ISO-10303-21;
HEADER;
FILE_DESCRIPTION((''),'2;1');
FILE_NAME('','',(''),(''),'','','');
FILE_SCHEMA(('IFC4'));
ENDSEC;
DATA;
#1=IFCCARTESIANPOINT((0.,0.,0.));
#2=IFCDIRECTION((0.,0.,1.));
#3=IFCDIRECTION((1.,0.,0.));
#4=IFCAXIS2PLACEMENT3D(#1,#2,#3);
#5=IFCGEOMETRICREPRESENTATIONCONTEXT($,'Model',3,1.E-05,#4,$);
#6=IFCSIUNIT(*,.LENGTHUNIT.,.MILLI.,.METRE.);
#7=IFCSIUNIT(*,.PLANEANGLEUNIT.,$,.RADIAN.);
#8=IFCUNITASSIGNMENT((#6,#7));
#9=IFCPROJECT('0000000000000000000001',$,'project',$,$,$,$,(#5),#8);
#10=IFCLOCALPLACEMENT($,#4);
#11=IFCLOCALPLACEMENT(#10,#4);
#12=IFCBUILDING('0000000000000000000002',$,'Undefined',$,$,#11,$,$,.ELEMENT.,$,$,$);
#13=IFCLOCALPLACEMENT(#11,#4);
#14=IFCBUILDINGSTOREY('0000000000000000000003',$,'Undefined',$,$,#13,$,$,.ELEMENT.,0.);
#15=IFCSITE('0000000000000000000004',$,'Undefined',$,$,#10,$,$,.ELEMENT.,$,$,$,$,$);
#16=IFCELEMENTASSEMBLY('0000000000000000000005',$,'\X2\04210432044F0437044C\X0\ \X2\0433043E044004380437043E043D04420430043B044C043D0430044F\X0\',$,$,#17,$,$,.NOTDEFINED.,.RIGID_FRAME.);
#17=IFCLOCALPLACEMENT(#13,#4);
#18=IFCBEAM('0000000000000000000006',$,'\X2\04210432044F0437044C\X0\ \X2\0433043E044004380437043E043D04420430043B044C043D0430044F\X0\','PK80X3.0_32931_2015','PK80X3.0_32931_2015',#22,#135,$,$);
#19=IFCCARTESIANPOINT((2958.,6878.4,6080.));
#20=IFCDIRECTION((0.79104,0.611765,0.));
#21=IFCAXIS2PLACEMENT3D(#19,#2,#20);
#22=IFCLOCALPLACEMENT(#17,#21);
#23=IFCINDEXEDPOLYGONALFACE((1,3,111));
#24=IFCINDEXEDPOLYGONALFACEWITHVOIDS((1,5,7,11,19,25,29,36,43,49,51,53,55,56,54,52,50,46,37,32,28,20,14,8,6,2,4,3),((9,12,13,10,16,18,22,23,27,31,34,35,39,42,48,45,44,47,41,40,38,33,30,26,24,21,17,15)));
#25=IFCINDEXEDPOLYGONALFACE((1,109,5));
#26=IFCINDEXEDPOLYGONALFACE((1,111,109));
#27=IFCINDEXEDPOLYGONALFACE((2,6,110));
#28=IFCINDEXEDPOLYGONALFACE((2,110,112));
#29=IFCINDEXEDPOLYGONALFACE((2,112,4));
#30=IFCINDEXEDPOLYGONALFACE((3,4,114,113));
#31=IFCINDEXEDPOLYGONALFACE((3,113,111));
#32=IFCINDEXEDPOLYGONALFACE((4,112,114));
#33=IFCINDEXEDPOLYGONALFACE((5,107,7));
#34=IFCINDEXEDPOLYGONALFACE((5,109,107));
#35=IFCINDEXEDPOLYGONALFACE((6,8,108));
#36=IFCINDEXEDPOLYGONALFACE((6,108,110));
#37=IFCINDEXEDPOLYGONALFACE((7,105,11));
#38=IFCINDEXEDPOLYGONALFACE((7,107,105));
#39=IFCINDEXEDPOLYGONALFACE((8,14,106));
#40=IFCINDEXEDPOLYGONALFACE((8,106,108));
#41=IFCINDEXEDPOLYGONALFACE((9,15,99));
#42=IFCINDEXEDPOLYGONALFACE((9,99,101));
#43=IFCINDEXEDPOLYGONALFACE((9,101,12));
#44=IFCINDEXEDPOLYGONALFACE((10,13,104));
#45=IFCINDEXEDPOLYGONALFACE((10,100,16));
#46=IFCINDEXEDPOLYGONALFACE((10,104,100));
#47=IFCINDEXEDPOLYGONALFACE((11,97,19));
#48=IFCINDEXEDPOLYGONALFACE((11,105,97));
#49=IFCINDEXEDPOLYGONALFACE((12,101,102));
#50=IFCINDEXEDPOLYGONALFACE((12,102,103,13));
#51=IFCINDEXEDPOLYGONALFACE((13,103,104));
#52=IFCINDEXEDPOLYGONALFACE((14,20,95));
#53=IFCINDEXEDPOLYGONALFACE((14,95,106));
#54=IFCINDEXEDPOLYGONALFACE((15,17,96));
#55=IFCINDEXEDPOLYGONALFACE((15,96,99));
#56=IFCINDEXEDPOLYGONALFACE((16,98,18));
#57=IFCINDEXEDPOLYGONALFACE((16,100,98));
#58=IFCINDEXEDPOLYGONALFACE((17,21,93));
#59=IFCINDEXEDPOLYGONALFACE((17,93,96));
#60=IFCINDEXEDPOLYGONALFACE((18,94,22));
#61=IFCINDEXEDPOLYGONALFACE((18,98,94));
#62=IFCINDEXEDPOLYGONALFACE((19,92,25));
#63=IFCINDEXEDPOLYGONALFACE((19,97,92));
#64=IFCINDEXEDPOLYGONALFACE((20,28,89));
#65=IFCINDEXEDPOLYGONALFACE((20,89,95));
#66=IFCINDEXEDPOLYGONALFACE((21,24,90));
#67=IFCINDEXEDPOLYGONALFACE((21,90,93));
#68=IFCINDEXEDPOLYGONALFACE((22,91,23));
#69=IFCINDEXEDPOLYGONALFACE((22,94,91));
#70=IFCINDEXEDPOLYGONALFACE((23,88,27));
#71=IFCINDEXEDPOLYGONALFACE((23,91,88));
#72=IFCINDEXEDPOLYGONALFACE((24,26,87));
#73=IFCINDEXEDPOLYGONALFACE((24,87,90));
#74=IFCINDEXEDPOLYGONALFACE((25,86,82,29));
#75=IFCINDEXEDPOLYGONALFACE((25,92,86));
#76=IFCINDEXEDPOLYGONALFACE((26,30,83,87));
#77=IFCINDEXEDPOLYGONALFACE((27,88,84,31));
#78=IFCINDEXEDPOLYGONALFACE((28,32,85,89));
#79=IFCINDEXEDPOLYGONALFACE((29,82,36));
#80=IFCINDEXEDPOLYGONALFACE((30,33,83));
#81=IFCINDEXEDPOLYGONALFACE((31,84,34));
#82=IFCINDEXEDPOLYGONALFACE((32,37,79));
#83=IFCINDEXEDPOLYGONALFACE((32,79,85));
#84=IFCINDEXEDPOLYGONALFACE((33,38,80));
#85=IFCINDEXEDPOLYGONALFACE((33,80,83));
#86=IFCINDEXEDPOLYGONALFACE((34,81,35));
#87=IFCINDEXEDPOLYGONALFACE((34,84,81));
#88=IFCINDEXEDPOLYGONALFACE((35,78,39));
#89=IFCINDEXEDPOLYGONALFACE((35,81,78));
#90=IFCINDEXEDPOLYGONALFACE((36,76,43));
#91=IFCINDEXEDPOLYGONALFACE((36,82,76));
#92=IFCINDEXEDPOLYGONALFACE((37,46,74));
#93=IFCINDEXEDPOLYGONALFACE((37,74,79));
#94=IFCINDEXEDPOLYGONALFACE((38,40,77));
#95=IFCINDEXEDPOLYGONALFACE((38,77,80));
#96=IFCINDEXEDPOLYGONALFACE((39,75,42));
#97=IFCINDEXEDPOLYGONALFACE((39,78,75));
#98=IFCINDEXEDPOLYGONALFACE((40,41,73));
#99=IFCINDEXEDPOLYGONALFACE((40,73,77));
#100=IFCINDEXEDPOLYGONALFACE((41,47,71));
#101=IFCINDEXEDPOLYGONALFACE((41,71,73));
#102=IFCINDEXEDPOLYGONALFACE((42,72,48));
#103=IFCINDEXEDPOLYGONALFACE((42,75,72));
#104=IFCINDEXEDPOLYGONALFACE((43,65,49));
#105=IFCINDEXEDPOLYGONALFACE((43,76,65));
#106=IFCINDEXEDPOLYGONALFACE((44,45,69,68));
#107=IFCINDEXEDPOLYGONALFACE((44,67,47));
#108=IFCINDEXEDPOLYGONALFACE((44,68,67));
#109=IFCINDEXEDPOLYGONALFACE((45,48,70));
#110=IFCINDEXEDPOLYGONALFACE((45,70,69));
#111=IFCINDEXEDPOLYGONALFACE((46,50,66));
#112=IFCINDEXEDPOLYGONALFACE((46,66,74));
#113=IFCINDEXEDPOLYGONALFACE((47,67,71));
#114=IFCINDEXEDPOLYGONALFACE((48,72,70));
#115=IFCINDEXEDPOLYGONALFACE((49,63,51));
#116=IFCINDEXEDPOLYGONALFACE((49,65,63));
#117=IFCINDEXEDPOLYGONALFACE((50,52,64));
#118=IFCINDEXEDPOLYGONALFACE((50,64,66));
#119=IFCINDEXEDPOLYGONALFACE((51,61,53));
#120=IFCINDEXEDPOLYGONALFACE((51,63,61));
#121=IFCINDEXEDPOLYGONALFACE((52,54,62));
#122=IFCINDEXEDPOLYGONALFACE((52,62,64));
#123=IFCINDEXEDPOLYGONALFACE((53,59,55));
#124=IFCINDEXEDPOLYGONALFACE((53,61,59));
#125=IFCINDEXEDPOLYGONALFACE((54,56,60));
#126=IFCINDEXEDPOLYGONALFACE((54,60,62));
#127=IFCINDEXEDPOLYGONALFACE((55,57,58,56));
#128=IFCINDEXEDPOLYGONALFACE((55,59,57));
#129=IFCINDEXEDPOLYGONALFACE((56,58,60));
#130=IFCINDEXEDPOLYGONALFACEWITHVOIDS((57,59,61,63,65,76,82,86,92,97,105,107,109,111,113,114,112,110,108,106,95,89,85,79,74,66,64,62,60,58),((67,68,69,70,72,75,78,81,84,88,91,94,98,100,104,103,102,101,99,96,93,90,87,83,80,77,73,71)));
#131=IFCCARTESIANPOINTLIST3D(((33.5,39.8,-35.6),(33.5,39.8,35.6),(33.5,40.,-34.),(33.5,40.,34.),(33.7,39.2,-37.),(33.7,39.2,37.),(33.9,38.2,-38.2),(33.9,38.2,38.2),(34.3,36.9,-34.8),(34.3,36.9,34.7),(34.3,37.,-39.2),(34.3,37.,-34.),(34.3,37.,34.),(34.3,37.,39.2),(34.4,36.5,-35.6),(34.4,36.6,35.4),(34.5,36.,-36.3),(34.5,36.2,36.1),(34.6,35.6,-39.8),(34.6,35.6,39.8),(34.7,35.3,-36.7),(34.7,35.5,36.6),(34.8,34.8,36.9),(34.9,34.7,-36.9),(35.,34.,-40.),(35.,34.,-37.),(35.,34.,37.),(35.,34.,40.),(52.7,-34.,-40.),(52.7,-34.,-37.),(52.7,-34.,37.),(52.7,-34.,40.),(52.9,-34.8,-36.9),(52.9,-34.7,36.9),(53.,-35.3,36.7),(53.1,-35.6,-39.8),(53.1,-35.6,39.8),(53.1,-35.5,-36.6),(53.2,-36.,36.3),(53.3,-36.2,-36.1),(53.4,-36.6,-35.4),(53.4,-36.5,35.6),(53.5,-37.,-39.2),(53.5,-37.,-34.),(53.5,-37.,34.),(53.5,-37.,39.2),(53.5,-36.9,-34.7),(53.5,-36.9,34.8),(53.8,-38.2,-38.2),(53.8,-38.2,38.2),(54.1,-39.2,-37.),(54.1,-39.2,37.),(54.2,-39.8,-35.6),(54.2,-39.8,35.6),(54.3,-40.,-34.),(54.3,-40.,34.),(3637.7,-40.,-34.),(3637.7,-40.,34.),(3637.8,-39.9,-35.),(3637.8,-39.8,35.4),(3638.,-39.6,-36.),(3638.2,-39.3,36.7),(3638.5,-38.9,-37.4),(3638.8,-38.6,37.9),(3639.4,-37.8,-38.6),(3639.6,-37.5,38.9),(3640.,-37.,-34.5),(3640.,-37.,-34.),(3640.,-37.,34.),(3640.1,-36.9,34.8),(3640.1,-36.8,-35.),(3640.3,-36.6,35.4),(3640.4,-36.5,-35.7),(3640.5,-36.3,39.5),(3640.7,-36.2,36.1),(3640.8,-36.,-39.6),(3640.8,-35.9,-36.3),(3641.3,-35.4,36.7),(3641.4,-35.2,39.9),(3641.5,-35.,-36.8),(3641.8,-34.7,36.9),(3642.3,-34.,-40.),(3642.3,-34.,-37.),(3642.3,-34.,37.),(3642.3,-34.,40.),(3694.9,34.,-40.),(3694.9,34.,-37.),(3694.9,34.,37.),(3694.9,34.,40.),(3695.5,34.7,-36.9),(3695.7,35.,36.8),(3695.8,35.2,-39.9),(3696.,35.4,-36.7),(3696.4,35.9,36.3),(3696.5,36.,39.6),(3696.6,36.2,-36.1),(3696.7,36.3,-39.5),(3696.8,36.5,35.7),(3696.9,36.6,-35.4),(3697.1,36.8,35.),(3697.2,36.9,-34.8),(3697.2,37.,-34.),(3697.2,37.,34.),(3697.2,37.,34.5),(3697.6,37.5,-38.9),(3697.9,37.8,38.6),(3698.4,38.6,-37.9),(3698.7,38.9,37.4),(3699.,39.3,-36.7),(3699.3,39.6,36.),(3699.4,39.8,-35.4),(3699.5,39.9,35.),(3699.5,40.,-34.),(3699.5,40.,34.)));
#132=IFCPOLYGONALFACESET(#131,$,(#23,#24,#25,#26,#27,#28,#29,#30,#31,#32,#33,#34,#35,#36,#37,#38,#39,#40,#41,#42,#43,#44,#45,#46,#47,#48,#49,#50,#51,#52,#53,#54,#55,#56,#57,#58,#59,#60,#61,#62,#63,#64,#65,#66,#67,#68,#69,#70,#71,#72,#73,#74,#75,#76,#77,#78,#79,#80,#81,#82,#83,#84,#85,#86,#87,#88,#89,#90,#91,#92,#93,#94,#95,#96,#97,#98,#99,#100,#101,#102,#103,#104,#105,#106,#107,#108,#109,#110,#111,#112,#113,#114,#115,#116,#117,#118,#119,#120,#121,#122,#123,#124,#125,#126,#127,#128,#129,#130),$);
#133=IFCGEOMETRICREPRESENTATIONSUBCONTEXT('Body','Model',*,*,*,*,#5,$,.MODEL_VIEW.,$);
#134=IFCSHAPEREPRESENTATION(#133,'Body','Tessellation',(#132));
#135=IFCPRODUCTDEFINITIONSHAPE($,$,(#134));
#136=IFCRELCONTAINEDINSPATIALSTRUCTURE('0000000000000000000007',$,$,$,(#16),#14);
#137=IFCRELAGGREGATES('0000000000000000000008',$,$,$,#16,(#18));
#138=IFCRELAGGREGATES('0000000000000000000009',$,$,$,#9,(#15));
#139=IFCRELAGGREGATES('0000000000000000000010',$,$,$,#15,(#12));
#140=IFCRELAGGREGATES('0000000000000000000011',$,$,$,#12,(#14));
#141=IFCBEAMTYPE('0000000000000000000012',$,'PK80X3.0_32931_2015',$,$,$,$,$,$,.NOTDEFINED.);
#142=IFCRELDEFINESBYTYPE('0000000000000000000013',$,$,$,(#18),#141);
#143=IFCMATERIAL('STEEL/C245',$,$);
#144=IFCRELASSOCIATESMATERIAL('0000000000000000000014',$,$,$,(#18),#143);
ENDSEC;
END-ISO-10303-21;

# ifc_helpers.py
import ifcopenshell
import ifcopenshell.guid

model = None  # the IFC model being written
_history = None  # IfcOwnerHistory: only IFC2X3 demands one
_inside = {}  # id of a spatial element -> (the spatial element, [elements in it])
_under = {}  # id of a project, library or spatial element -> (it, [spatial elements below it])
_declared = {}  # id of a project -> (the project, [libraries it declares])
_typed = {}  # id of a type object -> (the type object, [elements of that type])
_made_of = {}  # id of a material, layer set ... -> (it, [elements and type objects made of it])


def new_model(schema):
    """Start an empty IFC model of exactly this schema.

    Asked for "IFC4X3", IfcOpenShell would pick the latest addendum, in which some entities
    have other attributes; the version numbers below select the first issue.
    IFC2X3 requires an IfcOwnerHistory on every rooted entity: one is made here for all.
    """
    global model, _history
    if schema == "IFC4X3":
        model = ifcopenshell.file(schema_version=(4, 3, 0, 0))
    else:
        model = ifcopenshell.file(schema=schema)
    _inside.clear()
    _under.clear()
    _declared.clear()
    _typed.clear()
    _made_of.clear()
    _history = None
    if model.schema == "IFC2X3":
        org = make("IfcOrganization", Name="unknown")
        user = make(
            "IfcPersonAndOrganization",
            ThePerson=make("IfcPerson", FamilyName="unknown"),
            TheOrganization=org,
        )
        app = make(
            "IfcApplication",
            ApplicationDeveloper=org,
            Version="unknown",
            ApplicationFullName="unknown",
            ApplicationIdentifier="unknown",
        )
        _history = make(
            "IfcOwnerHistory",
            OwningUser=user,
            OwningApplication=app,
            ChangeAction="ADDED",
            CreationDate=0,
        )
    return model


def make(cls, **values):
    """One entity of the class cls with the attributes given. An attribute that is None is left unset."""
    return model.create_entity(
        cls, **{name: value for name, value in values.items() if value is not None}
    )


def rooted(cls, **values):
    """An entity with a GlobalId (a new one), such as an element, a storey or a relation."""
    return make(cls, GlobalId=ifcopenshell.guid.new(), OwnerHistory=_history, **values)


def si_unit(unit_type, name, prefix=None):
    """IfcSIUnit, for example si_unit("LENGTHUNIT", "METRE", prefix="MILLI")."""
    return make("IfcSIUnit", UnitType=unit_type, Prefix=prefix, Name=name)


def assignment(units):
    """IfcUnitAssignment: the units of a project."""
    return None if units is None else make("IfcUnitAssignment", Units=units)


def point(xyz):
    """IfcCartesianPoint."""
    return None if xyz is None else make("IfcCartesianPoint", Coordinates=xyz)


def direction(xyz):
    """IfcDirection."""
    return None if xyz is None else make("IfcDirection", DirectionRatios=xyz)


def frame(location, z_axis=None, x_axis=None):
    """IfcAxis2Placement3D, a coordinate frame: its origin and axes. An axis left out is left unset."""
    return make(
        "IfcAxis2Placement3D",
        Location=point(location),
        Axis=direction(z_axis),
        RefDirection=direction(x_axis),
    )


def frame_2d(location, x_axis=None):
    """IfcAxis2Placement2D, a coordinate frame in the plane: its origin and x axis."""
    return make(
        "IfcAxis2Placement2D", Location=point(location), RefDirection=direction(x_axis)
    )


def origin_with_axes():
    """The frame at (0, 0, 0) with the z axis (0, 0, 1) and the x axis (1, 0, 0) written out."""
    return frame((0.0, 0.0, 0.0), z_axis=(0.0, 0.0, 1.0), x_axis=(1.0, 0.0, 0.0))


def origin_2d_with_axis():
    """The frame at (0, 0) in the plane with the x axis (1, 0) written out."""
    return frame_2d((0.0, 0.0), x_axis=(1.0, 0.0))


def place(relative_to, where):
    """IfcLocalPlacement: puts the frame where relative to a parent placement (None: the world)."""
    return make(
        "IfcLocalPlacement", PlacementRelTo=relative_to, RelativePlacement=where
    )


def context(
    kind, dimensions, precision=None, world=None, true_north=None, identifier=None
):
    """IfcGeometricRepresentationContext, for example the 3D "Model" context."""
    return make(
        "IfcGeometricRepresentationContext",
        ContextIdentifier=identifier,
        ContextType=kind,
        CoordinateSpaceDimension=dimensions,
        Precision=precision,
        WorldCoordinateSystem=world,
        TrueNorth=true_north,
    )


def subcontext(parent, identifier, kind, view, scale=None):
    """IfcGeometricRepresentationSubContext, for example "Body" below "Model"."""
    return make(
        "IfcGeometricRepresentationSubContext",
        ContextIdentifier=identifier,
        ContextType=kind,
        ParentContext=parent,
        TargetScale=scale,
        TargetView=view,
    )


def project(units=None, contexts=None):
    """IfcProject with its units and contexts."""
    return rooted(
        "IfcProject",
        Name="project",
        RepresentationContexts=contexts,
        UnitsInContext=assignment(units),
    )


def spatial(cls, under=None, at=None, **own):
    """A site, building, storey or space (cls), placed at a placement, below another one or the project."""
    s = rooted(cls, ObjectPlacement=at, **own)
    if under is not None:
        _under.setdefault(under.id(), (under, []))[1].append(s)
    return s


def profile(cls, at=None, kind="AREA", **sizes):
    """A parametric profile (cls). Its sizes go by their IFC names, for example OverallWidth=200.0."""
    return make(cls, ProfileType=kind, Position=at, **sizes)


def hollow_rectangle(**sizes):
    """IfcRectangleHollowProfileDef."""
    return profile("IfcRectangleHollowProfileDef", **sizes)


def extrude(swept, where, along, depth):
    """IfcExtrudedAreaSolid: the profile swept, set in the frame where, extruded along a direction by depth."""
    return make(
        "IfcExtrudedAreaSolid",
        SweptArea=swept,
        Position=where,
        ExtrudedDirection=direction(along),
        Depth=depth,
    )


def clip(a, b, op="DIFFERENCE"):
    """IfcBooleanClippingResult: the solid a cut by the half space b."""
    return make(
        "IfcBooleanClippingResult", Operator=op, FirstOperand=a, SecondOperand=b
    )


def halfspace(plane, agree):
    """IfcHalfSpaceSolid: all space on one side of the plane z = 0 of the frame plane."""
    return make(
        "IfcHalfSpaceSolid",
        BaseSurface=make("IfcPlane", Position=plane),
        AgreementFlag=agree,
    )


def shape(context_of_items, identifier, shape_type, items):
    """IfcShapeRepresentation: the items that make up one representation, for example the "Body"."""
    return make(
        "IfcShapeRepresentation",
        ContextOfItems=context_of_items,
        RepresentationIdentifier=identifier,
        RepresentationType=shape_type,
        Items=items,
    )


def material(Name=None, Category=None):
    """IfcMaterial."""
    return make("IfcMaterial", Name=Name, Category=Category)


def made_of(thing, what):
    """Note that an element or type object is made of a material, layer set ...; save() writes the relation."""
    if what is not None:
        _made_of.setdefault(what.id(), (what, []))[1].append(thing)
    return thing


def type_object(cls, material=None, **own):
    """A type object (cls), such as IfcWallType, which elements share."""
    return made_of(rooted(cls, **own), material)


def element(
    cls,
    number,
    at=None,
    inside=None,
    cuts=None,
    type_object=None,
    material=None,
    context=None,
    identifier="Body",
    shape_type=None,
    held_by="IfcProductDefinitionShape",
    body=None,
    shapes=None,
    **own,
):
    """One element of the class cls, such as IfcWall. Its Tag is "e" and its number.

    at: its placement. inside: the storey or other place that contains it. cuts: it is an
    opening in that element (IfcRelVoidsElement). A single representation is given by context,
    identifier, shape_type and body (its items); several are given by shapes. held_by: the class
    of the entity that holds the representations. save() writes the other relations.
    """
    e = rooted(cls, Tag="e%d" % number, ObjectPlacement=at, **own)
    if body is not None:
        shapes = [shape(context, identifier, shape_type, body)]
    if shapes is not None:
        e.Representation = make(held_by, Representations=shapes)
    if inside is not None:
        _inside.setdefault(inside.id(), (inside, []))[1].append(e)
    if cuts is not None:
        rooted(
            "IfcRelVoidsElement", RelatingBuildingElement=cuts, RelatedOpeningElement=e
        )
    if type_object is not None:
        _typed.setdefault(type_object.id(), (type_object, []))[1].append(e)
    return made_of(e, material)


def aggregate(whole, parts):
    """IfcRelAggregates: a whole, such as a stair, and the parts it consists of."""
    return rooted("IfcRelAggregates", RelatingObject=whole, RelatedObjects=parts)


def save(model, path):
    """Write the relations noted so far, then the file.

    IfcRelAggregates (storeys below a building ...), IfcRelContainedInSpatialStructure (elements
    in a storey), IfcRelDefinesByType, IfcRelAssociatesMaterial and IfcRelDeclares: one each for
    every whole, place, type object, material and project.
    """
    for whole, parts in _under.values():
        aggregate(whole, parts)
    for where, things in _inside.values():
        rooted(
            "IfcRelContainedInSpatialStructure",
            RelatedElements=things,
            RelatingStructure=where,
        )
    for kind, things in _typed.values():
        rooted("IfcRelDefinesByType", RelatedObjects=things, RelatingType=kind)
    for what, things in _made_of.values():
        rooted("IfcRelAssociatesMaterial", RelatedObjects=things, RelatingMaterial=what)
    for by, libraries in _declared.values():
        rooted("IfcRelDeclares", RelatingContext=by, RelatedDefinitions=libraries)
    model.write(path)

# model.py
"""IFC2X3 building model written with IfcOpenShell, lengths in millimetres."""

from ifc_helpers import new_model, si_unit, frame, origin_with_axes, origin_2d_with_axis, place, context, subcontext, project, spatial, hollow_rectangle, extrude, clip, halfspace, material, type_object, element, aggregate, save


model = new_model("IFC2X3")

# Units and contexts
model_context = context("Model", 3, precision=1e-05, world=origin_with_axes())
body_context = subcontext(model_context, "Body", "Model", "MODEL_VIEW")
ifc_project = project(units=[si_unit("LENGTHUNIT", "METRE", prefix="MILLI"), si_unit("PLANEANGLEUNIT", "RADIAN")], contexts=[model_context])

# Site, building, storey
site_placement = place(None, origin_with_axes())
site = spatial("IfcSite", under=ifc_project, at=site_placement, Name="Undefined", CompositionType="ELEMENT")
building_placement = place(site_placement, origin_with_axes())
building = spatial("IfcBuilding", under=site, at=building_placement, Name="Undefined", CompositionType="ELEMENT")
storey_placement = place(building_placement, origin_with_axes())
storey = spatial("IfcBuildingStorey", under=building, at=storey_placement, Name="Undefined", CompositionType="ELEMENT", Elevation=0.0)

# Shared definitions
ifc_material = material(Name="STEEL/C245")

# Element assembly, beam
assembly_1_placement = place(storey_placement, origin_with_axes())
assembly_1 = element("IfcElementAssembly", 1, at=assembly_1_placement, inside=storey, Name="Связь горизонтальная", AssemblyPlace="NOTDEFINED", PredefinedType="RIGID_FRAME")
beam_type_1 = type_object("IfcBeamType", Name="PK80X3.0_32931_2015", PredefinedType="NOTDEFINED")
beam_1_placement = place(assembly_1_placement, frame((2958.0, 6878.4, 6080.0), z_axis=(0.0, 0.0, 1.0), x_axis=(0.79104, 0.611765, 0.0)))
beam_1 = element("IfcBeam", 2, at=beam_1_placement, type_object=beam_type_1, material=ifc_material, Name="Связь горизонтальная", Description="PK80X3.0_32931_2015", ObjectType="PK80X3.0_32931_2015", context=body_context, shape_type="Clipping", body=[
    clip(clip(extrude(hollow_rectangle(XDim=80.0, YDim=80.0, WallThickness=3.0, InnerFilletRadius=3.0, OuterFilletRadius=6.0, at=origin_2d_with_axis()), frame((3741.6, 0.0, 0.0), z_axis=(-1.0, 0.0, 0.0), x_axis=(0.0, -1.0, 0.0)), (0.0, 0.0, 1.0), 3770.7), halfspace(frame((3583.9, -109.6, 40.0), z_axis=(-0.79104, 0.611765, 0.0), x_axis=(0.0, 0.0, 1.0)), True)), halfspace(frame((25.2, 72.0, 40.0), z_axis=(-0.96786, -0.251488, 0.0), x_axis=(0.0, 0.0, 1.0)), False)),
])
aggregate(assembly_1, [beam_1])

save(model, "model.ifc")
